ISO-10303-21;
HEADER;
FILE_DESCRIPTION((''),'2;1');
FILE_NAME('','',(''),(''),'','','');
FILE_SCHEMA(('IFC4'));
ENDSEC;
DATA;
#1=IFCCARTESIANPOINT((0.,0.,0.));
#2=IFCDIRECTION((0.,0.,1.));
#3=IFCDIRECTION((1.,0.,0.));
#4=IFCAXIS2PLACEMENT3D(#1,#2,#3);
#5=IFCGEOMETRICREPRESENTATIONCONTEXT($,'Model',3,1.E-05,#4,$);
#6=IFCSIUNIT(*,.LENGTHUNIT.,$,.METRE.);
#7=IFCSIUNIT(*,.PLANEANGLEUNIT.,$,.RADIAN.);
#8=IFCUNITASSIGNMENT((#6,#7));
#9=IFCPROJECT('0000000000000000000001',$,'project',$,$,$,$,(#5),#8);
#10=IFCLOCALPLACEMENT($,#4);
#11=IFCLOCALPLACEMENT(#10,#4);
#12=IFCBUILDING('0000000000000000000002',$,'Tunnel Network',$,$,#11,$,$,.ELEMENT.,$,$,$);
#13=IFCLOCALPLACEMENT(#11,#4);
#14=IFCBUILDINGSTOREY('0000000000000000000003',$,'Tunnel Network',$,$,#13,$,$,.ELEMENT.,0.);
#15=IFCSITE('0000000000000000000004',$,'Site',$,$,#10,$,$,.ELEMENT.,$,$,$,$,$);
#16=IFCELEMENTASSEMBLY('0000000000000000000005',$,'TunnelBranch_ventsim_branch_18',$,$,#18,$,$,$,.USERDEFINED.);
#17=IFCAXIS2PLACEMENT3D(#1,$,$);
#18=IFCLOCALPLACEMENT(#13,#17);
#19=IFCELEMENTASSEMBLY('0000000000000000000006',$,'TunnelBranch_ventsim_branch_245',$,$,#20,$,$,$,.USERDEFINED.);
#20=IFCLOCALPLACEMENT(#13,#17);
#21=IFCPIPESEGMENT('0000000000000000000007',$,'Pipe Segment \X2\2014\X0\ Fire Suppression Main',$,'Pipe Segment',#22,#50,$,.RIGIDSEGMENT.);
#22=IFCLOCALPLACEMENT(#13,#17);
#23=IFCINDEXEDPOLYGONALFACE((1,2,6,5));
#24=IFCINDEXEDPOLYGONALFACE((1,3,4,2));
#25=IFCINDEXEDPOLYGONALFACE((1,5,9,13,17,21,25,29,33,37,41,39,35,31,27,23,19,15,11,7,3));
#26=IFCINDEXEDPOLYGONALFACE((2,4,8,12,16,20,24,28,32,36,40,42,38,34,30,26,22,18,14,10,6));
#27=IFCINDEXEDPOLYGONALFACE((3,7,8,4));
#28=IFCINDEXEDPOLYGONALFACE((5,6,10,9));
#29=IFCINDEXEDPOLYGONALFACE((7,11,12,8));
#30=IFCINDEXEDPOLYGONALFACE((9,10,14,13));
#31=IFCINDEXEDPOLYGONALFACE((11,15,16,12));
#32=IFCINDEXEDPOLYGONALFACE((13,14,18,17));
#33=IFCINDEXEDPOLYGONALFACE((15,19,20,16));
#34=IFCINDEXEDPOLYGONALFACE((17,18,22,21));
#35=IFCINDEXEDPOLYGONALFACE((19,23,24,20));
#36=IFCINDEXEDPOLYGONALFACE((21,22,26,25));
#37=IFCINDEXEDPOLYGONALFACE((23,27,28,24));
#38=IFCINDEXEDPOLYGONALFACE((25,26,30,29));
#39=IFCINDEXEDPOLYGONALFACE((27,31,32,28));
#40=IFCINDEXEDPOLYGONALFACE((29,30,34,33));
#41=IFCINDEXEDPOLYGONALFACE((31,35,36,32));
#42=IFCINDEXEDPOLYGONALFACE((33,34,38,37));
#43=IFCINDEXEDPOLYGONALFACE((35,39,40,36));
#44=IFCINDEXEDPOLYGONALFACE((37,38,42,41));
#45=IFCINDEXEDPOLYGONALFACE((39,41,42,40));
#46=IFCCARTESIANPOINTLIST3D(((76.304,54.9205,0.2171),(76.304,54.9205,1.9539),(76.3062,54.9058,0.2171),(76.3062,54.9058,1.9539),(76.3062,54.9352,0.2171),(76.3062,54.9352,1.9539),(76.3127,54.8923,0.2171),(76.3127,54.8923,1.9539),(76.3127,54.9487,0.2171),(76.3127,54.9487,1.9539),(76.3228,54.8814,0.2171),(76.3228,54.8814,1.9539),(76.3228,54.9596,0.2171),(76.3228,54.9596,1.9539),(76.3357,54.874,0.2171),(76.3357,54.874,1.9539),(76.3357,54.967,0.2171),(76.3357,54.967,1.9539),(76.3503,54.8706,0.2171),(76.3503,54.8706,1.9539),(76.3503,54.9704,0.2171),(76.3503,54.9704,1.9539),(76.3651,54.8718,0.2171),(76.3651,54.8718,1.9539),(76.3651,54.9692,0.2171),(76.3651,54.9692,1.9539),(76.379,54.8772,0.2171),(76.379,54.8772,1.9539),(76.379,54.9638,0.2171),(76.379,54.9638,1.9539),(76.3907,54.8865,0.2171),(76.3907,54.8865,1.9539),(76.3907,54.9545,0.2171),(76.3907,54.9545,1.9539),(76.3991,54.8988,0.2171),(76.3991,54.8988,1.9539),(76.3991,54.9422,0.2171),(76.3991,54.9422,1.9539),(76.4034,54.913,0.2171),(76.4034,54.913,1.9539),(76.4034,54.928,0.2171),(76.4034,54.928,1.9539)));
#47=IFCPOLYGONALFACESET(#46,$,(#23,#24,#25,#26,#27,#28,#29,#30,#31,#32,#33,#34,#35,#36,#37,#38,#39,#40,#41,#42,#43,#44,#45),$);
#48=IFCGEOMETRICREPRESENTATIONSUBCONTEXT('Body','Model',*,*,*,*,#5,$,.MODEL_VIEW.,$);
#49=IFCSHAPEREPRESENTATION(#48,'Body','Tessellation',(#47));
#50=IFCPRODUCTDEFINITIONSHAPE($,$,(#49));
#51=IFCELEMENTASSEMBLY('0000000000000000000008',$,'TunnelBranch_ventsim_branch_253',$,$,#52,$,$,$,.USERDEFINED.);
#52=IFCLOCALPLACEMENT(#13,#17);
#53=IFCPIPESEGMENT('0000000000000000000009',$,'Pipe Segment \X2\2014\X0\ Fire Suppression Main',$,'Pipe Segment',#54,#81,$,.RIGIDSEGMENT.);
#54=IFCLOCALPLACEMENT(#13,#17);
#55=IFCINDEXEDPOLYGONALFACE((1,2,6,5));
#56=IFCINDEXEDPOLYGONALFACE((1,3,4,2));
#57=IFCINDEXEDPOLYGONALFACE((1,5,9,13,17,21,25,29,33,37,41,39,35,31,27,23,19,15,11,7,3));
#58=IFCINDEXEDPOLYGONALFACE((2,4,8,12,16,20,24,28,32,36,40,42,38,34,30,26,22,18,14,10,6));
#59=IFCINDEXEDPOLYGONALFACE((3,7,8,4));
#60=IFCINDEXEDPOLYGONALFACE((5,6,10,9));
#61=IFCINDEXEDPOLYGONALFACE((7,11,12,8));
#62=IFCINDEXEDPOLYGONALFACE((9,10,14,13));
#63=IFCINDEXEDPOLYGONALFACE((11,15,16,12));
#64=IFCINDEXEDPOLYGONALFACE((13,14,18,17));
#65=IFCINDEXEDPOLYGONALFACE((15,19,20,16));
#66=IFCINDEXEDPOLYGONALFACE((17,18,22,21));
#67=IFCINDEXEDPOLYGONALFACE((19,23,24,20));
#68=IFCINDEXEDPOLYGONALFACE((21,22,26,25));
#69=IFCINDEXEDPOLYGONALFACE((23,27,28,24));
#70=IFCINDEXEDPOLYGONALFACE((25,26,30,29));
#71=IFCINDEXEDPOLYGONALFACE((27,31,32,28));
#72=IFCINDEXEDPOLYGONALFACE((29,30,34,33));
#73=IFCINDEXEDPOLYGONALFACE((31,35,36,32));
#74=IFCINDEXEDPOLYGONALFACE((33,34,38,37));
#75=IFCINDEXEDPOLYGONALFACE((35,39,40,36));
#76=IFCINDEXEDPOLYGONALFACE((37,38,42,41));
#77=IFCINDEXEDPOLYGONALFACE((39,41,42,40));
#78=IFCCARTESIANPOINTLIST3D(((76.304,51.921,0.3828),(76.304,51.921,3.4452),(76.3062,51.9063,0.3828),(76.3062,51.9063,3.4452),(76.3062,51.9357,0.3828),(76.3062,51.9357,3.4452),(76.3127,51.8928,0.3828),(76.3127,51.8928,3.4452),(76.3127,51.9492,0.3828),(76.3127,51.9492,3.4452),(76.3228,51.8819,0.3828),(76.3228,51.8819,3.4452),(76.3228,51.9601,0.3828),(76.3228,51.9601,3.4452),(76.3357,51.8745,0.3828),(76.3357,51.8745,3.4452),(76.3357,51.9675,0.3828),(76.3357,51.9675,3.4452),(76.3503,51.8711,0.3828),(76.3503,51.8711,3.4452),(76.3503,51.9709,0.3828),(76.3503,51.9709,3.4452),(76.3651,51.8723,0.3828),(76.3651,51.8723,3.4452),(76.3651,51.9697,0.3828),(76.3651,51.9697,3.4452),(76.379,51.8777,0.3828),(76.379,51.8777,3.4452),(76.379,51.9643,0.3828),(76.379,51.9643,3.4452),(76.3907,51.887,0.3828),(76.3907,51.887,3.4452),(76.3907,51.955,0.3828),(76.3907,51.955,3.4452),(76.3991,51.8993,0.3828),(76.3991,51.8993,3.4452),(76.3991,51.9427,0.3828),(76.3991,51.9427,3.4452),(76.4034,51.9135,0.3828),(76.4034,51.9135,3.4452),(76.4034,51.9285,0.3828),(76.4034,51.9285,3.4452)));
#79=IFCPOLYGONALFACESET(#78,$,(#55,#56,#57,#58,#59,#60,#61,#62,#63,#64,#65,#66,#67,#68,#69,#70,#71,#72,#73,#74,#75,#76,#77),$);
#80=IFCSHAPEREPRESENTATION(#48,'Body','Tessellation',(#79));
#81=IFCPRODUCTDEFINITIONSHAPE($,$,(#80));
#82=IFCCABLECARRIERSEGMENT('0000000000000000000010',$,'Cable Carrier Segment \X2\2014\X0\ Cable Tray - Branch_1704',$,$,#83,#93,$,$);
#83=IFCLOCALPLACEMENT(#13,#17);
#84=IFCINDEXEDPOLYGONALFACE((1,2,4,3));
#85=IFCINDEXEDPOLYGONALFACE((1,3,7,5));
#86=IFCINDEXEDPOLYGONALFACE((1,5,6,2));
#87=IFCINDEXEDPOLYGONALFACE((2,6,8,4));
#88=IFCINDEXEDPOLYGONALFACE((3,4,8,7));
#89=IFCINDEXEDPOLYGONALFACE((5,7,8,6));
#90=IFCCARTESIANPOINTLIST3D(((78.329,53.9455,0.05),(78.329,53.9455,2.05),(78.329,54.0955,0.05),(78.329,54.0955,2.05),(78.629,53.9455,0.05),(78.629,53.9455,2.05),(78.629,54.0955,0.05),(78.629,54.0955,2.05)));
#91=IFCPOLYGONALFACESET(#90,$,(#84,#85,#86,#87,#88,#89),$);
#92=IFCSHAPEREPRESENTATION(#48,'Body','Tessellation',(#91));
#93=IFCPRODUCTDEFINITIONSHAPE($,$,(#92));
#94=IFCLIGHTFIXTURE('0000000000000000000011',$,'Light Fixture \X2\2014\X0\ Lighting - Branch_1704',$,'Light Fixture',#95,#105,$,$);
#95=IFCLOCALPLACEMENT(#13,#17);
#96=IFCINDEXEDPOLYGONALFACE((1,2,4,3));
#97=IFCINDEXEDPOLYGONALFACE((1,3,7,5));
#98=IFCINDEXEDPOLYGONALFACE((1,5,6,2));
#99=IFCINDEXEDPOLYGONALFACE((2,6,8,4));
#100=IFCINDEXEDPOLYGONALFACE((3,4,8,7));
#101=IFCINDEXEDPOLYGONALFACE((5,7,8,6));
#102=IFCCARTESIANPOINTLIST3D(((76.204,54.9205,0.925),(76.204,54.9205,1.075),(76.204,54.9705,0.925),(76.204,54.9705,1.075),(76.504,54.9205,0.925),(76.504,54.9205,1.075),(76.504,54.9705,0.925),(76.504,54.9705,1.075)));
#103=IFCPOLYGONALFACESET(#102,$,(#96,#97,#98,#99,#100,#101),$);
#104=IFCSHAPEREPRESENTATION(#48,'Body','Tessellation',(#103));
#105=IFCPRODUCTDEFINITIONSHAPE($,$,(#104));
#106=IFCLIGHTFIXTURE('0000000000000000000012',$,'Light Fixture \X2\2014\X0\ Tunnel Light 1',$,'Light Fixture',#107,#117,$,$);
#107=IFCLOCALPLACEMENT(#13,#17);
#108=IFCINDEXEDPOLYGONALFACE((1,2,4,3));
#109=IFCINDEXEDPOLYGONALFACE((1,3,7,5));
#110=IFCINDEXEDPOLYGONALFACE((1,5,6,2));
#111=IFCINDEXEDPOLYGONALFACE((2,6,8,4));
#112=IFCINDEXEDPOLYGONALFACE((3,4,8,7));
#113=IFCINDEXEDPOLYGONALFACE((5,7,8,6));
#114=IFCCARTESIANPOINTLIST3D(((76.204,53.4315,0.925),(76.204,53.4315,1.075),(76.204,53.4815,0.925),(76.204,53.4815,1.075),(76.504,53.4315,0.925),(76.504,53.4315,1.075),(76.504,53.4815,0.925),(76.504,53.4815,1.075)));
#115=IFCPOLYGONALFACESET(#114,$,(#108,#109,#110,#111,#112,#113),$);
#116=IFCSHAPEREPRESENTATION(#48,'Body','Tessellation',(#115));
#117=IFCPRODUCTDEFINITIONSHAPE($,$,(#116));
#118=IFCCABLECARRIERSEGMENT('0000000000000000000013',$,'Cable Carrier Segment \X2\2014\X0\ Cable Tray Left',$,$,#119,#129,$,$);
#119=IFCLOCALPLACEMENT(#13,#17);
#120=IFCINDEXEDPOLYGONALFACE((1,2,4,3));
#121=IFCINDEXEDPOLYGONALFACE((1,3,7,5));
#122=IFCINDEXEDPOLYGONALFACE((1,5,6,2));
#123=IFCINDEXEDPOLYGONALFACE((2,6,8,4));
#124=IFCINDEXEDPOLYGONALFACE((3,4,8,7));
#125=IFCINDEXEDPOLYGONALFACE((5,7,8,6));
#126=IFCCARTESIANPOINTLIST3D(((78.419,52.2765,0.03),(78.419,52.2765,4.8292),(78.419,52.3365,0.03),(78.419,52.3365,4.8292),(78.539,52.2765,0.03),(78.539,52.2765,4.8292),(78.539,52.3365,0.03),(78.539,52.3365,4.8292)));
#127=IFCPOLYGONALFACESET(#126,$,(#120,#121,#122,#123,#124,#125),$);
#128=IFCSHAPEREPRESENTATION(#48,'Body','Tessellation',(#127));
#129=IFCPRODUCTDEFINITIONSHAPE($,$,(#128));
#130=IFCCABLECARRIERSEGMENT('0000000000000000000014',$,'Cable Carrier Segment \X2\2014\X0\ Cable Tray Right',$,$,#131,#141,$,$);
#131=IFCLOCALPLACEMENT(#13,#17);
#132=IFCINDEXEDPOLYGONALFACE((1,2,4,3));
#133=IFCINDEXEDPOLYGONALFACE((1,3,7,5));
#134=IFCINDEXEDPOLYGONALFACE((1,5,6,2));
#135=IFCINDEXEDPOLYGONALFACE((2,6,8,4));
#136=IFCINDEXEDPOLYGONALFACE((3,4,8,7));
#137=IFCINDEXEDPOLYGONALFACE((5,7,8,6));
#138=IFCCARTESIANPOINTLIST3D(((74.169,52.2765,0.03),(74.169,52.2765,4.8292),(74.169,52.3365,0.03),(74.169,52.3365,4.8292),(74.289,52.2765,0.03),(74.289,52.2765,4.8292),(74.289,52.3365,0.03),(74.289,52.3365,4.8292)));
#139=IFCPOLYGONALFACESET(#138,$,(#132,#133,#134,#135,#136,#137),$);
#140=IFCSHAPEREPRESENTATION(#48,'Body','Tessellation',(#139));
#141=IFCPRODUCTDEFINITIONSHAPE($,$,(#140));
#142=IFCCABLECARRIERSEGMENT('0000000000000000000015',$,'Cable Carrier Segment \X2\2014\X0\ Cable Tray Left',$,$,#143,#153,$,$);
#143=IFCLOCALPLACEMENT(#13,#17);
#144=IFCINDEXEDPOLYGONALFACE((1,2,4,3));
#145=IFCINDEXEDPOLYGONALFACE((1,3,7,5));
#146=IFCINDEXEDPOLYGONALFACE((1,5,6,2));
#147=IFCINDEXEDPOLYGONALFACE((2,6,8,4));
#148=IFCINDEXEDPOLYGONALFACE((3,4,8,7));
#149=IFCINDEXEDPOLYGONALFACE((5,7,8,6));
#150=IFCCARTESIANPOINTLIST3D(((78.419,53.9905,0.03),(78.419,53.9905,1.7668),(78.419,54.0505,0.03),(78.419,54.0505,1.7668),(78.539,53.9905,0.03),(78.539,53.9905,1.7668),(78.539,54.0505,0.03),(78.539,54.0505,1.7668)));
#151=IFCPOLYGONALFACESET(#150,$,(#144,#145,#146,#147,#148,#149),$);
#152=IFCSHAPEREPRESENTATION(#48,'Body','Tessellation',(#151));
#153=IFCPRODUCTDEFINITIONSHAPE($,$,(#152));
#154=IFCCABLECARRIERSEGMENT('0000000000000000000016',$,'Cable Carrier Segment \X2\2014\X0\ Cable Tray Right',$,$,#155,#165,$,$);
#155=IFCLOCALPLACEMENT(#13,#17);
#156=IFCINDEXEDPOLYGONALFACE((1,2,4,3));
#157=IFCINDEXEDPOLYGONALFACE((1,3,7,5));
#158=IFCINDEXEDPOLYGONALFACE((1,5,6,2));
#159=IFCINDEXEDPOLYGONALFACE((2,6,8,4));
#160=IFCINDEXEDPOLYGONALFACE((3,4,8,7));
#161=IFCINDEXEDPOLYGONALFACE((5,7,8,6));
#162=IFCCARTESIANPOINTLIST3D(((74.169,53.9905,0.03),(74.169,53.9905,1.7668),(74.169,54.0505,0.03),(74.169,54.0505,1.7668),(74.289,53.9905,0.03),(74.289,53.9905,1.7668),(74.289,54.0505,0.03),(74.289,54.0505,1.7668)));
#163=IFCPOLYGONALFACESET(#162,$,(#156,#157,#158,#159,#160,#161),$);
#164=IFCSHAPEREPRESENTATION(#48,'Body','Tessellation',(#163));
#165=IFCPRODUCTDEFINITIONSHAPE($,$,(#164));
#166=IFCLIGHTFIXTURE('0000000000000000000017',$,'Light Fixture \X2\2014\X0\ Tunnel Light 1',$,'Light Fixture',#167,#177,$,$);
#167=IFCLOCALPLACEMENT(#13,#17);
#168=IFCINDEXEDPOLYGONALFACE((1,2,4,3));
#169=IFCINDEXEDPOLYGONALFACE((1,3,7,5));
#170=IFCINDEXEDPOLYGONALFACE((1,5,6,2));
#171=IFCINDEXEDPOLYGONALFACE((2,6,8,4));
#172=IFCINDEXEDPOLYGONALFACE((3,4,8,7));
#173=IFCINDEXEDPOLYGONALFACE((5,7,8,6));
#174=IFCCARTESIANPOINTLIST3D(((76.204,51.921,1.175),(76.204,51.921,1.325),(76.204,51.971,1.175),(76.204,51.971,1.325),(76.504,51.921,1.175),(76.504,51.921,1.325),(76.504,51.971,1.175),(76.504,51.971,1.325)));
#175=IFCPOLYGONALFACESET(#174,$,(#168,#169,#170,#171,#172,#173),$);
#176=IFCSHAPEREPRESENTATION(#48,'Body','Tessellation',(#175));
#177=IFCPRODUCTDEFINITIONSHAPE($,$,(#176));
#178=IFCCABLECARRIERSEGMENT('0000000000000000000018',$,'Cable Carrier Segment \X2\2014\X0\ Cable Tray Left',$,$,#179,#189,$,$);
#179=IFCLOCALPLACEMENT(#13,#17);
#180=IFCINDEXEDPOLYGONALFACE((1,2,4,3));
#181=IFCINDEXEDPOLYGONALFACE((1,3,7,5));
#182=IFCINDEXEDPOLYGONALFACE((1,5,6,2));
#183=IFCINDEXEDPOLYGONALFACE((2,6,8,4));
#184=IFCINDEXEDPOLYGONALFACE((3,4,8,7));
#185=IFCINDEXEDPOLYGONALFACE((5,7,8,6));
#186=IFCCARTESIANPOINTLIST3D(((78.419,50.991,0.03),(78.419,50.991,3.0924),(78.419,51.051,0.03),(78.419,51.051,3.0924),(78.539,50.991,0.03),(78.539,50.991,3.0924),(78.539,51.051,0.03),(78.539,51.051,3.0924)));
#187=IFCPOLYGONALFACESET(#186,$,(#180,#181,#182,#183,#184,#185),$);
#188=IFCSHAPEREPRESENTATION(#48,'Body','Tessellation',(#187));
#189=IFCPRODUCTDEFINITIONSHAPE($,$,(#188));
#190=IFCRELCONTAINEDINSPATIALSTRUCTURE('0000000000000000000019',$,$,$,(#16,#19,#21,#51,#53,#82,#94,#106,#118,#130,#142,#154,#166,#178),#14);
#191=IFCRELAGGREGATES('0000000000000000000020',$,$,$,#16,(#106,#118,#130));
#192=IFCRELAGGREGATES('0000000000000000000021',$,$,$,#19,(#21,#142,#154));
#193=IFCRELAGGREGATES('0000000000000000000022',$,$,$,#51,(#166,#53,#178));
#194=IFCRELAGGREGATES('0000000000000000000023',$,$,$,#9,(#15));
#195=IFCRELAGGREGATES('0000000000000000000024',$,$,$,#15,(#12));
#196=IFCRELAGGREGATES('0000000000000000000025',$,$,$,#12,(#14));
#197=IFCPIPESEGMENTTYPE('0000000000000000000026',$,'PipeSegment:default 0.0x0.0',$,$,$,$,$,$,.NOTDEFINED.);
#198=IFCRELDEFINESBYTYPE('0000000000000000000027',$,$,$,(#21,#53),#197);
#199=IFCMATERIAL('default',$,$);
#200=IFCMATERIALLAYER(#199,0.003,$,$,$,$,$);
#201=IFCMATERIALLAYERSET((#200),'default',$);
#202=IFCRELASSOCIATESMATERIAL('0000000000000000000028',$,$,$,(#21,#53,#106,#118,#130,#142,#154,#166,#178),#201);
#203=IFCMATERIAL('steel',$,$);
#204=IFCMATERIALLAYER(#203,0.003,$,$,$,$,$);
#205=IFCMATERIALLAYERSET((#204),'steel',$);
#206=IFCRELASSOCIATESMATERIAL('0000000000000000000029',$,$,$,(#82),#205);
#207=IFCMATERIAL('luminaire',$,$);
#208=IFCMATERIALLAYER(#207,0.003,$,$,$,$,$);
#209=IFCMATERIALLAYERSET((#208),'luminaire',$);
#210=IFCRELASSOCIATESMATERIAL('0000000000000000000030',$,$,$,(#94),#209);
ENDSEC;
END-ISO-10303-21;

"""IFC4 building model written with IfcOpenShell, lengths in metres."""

from ifc_helpers import new_model, si_unit, frame, origin_with_axes, origin_2d_with_axis, place, context, subcontext, project, spatial, rectangle, circle, extrude, material, layer, layer_set, layer_usage, type_object, element, aggregate, save


model = new_model("IFC4")

# Units and contexts
model_context = context("Model", 3, precision=1e-05, world=origin_with_axes())
body_context = subcontext(model_context, "Body", "Model", "MODEL_VIEW")
ifc_project = project(units=[si_unit("LENGTHUNIT", "METRE"), si_unit("PLANEANGLEUNIT", "RADIAN")], contexts=[model_context])

# Site, building, storey
site_placement = place(None, origin_with_axes())
site = spatial("IfcSite", under=ifc_project, at=site_placement, Name="Site", CompositionType="ELEMENT")
building_placement = place(site_placement, origin_with_axes())
building = spatial("IfcBuilding", under=site, at=building_placement, Name="Tunnel Network", CompositionType="ELEMENT")
storey_placement = place(building_placement, origin_with_axes())
storey = spatial("IfcBuildingStorey", under=building, at=storey_placement, Name="Tunnel Network", CompositionType="ELEMENT", Elevation=0.0)

# Element assemblies, pipe segments
assembly_1_placement = place(storey_placement, frame((76.354, 53.4315, 1.0), z_axis=(0.0, 1.0, 0.0), x_axis=(-1.0, 0.0, 0.0)))
assembly_1 = element("IfcElementAssembly", 1, at=assembly_1_placement, inside=storey, Name="TunnelBranch_ventsim_branch_18", PredefinedType="USERDEFINED")
ifc_material_1 = material(Name="default")
ifc_layer_1 = layer(ifc_material_1, 0.003)
ifc_layer_set_1 = layer_set([ifc_layer_1], Name="default")
pipe_segment_type = type_object("IfcPipeSegmentType", Name="PipeSegment:default 0.0x0.0")
assembly_2_placement = place(storey_placement, frame((76.354, 54.9205, 1.0), z_axis=(0.0, 1.0, 0.0), x_axis=(-1.0, 0.0, 0.0)))
assembly_2 = element("IfcElementAssembly", 2, at=assembly_2_placement, inside=storey, Name="TunnelBranch_ventsim_branch_245", PredefinedType="USERDEFINED")
ifc_layer_usage_1 = layer_usage(ifc_layer_set_1, "AXIS2", "POSITIVE", 0.0)
pipe_segment_1_placement = place(storey_placement, frame((76.354, 54.9205, 0.2171), z_axis=(0.0, 0.0, 1.0), x_axis=(-1.0, 0.0, 0.0)))
pipe_segment_1 = element("IfcPipeSegment", 3, at=pipe_segment_1_placement, inside=storey, type_object=pipe_segment_type, material=ifc_layer_usage_1, Name="Pipe Segment — Fire Suppression Main", ObjectType="Pipe Segment", PredefinedType="RIGIDSEGMENT", context=body_context, shape_type="SweptSolid", body=[
    extrude(circle(Radius=0.05, at=origin_2d_with_axis()), origin_with_axes(), (0.0, 0.0, 1.0), 1.7368),
])
assembly_3_placement = place(storey_placement, frame((76.354, 51.921, 1.25), z_axis=(0.0, 1.0, 0.0), x_axis=(-1.0, 0.0, 0.0)))
assembly_3 = element("IfcElementAssembly", 4, at=assembly_3_placement, inside=storey, Name="TunnelBranch_ventsim_branch_253", PredefinedType="USERDEFINED")
ifc_layer_usage_2 = layer_usage(ifc_layer_set_1, "AXIS2", "POSITIVE", 0.0)
pipe_segment_2_placement = place(storey_placement, frame((76.354, 51.921, 0.3828), z_axis=(0.0, 0.0, 1.0), x_axis=(-1.0, 0.0, 0.0)))
pipe_segment_2 = element("IfcPipeSegment", 5, at=pipe_segment_2_placement, inside=storey, type_object=pipe_segment_type, material=ifc_layer_usage_2, Name="Pipe Segment — Fire Suppression Main", ObjectType="Pipe Segment", PredefinedType="RIGIDSEGMENT", context=body_context, shape_type="SweptSolid", body=[
    extrude(circle(Radius=0.05, at=origin_2d_with_axis()), origin_with_axes(), (0.0, 0.0, 1.0), 3.0624),
])

# Cable carrier segment
ifc_material_2 = material(Name="steel")
ifc_layer_2 = layer(ifc_material_2, 0.003)
ifc_layer_set_2 = layer_set([ifc_layer_2], Name="steel")
ifc_layer_usage_3 = layer_usage(ifc_layer_set_2, "AXIS2", "POSITIVE", 0.0)
cable_carrier_segment_1_placement = place(storey_placement, frame((78.479, 54.0205, 0.05), z_axis=(0.0, 0.0, 1.0), x_axis=(-1.0, 0.0, 0.0)))
element("IfcCableCarrierSegment", 6, at=cable_carrier_segment_1_placement, inside=storey, material=ifc_layer_usage_3, Name="Cable Carrier Segment — Cable Tray - Branch_1704", context=body_context, shape_type="SweptSolid", body=[
    extrude(rectangle(XDim=0.3, YDim=0.15, at=origin_2d_with_axis()), origin_with_axes(), (0.0, 0.0, 1.0), 2.0),
])

# Light fixtures
ifc_material_3 = material(Name="luminaire")
ifc_layer_3 = layer(ifc_material_3, 0.003)
ifc_layer_set_3 = layer_set([ifc_layer_3], Name="luminaire")
ifc_layer_usage_4 = layer_usage(ifc_layer_set_3, "AXIS2", "POSITIVE", 0.0)
light_fixture_1_placement = place(storey_placement, frame((76.354, 54.9205, 1.0), z_axis=(0.0, 1.0, 0.0), x_axis=(-1.0, 0.0, 0.0)))
element("IfcLightFixture", 7, at=light_fixture_1_placement, inside=storey, material=ifc_layer_usage_4, Name="Light Fixture — Lighting - Branch_1704", ObjectType="Light Fixture", context=body_context, shape_type="SweptSolid", body=[
    extrude(rectangle(XDim=0.3, YDim=0.15, at=origin_2d_with_axis()), origin_with_axes(), (0.0, 0.0, 1.0), 0.05),
])
ifc_layer_usage_5 = layer_usage(ifc_layer_set_1, "AXIS2", "POSITIVE", 0.0)
light_fixture_2_placement = place(storey_placement, frame((76.354, 53.4315, 1.0), z_axis=(0.0, 1.0, 0.0), x_axis=(-1.0, 0.0, 0.0)))
light_fixture_2 = element("IfcLightFixture", 8, at=light_fixture_2_placement, inside=storey, material=ifc_layer_usage_5, Name="Light Fixture — Tunnel Light 1", ObjectType="Light Fixture", context=body_context, shape_type="SweptSolid", body=[
    extrude(rectangle(XDim=0.3, YDim=0.15, at=origin_2d_with_axis()), origin_with_axes(), (0.0, 0.0, 1.0), 0.05),
])

# Cable carrier segments
ifc_layer_usage_6 = layer_usage(ifc_layer_set_1, "AXIS2", "POSITIVE", 0.0)
cable_carrier_segment_2_placement = place(storey_placement, frame((78.479, 52.3065, 0.03), z_axis=(0.0, 0.0, 1.0), x_axis=(-1.0, 0.0, 0.0)))
cable_carrier_segment_2 = element("IfcCableCarrierSegment", 9, at=cable_carrier_segment_2_placement, inside=storey, material=ifc_layer_usage_6, Name="Cable Carrier Segment — Cable Tray Left", context=body_context, shape_type="SweptSolid", body=[
    extrude(rectangle(XDim=0.12, YDim=0.06, at=origin_2d_with_axis()), origin_with_axes(), (0.0, 0.0, 1.0), 4.7992),
])
ifc_layer_usage_7 = layer_usage(ifc_layer_set_1, "AXIS2", "POSITIVE", 0.0)
cable_carrier_segment_3_placement = place(storey_placement, frame((74.229, 52.3065, 0.03), z_axis=(0.0, 0.0, 1.0), x_axis=(-1.0, 0.0, 0.0)))
cable_carrier_segment_3 = element("IfcCableCarrierSegment", 10, at=cable_carrier_segment_3_placement, inside=storey, material=ifc_layer_usage_7, Name="Cable Carrier Segment — Cable Tray Right", context=body_context, shape_type="SweptSolid", body=[
    extrude(rectangle(XDim=0.12, YDim=0.06, at=origin_2d_with_axis()), origin_with_axes(), (0.0, 0.0, 1.0), 4.7992),
])
aggregate(assembly_1, [light_fixture_2, cable_carrier_segment_2, cable_carrier_segment_3])

# Cable carrier segments
ifc_layer_usage_8 = layer_usage(ifc_layer_set_1, "AXIS2", "POSITIVE", 0.0)
cable_carrier_segment_4_placement = place(storey_placement, frame((78.479, 54.0205, 0.03), z_axis=(0.0, 0.0, 1.0), x_axis=(-1.0, 0.0, 0.0)))
cable_carrier_segment_4 = element("IfcCableCarrierSegment", 11, at=cable_carrier_segment_4_placement, inside=storey, material=ifc_layer_usage_8, Name="Cable Carrier Segment — Cable Tray Left", context=body_context, shape_type="SweptSolid", body=[
    extrude(rectangle(XDim=0.12, YDim=0.06, at=origin_2d_with_axis()), origin_with_axes(), (0.0, 0.0, 1.0), 1.7368),
])
ifc_layer_usage_9 = layer_usage(ifc_layer_set_1, "AXIS2", "POSITIVE", 0.0)
cable_carrier_segment_5_placement = place(storey_placement, frame((74.229, 54.0205, 0.03), z_axis=(0.0, 0.0, 1.0), x_axis=(-1.0, 0.0, 0.0)))
cable_carrier_segment_5 = element("IfcCableCarrierSegment", 12, at=cable_carrier_segment_5_placement, inside=storey, material=ifc_layer_usage_9, Name="Cable Carrier Segment — Cable Tray Right", context=body_context, shape_type="SweptSolid", body=[
    extrude(rectangle(XDim=0.12, YDim=0.06, at=origin_2d_with_axis()), origin_with_axes(), (0.0, 0.0, 1.0), 1.7368),
])
aggregate(assembly_2, [pipe_segment_1, cable_carrier_segment_4, cable_carrier_segment_5])

# Light fixture
ifc_layer_usage_10 = layer_usage(ifc_layer_set_1, "AXIS2", "POSITIVE", 0.0)
light_fixture_3_placement = place(storey_placement, frame((76.354, 51.921, 1.25), z_axis=(0.0, 1.0, 0.0), x_axis=(-1.0, 0.0, 0.0)))
light_fixture_3 = element("IfcLightFixture", 13, at=light_fixture_3_placement, inside=storey, material=ifc_layer_usage_10, Name="Light Fixture — Tunnel Light 1", ObjectType="Light Fixture", context=body_context, shape_type="SweptSolid", body=[
    extrude(rectangle(XDim=0.3, YDim=0.15, at=origin_2d_with_axis()), origin_with_axes(), (0.0, 0.0, 1.0), 0.05),
])

# Cable carrier segment
ifc_layer_usage_11 = layer_usage(ifc_layer_set_1, "AXIS2", "POSITIVE", 0.0)
cable_carrier_segment_6_placement = place(storey_placement, frame((78.479, 51.021, 0.03), z_axis=(0.0, 0.0, 1.0), x_axis=(-1.0, 0.0, 0.0)))
cable_carrier_segment_6 = element("IfcCableCarrierSegment", 14, at=cable_carrier_segment_6_placement, inside=storey, material=ifc_layer_usage_11, Name="Cable Carrier Segment — Cable Tray Left", context=body_context, shape_type="SweptSolid", body=[
    extrude(rectangle(XDim=0.12, YDim=0.06, at=origin_2d_with_axis()), origin_with_axes(), (0.0, 0.0, 1.0), 3.0624),
])
aggregate(assembly_3, [light_fixture_3, pipe_segment_2, cable_carrier_segment_6])

save(model, "model.ifc")
